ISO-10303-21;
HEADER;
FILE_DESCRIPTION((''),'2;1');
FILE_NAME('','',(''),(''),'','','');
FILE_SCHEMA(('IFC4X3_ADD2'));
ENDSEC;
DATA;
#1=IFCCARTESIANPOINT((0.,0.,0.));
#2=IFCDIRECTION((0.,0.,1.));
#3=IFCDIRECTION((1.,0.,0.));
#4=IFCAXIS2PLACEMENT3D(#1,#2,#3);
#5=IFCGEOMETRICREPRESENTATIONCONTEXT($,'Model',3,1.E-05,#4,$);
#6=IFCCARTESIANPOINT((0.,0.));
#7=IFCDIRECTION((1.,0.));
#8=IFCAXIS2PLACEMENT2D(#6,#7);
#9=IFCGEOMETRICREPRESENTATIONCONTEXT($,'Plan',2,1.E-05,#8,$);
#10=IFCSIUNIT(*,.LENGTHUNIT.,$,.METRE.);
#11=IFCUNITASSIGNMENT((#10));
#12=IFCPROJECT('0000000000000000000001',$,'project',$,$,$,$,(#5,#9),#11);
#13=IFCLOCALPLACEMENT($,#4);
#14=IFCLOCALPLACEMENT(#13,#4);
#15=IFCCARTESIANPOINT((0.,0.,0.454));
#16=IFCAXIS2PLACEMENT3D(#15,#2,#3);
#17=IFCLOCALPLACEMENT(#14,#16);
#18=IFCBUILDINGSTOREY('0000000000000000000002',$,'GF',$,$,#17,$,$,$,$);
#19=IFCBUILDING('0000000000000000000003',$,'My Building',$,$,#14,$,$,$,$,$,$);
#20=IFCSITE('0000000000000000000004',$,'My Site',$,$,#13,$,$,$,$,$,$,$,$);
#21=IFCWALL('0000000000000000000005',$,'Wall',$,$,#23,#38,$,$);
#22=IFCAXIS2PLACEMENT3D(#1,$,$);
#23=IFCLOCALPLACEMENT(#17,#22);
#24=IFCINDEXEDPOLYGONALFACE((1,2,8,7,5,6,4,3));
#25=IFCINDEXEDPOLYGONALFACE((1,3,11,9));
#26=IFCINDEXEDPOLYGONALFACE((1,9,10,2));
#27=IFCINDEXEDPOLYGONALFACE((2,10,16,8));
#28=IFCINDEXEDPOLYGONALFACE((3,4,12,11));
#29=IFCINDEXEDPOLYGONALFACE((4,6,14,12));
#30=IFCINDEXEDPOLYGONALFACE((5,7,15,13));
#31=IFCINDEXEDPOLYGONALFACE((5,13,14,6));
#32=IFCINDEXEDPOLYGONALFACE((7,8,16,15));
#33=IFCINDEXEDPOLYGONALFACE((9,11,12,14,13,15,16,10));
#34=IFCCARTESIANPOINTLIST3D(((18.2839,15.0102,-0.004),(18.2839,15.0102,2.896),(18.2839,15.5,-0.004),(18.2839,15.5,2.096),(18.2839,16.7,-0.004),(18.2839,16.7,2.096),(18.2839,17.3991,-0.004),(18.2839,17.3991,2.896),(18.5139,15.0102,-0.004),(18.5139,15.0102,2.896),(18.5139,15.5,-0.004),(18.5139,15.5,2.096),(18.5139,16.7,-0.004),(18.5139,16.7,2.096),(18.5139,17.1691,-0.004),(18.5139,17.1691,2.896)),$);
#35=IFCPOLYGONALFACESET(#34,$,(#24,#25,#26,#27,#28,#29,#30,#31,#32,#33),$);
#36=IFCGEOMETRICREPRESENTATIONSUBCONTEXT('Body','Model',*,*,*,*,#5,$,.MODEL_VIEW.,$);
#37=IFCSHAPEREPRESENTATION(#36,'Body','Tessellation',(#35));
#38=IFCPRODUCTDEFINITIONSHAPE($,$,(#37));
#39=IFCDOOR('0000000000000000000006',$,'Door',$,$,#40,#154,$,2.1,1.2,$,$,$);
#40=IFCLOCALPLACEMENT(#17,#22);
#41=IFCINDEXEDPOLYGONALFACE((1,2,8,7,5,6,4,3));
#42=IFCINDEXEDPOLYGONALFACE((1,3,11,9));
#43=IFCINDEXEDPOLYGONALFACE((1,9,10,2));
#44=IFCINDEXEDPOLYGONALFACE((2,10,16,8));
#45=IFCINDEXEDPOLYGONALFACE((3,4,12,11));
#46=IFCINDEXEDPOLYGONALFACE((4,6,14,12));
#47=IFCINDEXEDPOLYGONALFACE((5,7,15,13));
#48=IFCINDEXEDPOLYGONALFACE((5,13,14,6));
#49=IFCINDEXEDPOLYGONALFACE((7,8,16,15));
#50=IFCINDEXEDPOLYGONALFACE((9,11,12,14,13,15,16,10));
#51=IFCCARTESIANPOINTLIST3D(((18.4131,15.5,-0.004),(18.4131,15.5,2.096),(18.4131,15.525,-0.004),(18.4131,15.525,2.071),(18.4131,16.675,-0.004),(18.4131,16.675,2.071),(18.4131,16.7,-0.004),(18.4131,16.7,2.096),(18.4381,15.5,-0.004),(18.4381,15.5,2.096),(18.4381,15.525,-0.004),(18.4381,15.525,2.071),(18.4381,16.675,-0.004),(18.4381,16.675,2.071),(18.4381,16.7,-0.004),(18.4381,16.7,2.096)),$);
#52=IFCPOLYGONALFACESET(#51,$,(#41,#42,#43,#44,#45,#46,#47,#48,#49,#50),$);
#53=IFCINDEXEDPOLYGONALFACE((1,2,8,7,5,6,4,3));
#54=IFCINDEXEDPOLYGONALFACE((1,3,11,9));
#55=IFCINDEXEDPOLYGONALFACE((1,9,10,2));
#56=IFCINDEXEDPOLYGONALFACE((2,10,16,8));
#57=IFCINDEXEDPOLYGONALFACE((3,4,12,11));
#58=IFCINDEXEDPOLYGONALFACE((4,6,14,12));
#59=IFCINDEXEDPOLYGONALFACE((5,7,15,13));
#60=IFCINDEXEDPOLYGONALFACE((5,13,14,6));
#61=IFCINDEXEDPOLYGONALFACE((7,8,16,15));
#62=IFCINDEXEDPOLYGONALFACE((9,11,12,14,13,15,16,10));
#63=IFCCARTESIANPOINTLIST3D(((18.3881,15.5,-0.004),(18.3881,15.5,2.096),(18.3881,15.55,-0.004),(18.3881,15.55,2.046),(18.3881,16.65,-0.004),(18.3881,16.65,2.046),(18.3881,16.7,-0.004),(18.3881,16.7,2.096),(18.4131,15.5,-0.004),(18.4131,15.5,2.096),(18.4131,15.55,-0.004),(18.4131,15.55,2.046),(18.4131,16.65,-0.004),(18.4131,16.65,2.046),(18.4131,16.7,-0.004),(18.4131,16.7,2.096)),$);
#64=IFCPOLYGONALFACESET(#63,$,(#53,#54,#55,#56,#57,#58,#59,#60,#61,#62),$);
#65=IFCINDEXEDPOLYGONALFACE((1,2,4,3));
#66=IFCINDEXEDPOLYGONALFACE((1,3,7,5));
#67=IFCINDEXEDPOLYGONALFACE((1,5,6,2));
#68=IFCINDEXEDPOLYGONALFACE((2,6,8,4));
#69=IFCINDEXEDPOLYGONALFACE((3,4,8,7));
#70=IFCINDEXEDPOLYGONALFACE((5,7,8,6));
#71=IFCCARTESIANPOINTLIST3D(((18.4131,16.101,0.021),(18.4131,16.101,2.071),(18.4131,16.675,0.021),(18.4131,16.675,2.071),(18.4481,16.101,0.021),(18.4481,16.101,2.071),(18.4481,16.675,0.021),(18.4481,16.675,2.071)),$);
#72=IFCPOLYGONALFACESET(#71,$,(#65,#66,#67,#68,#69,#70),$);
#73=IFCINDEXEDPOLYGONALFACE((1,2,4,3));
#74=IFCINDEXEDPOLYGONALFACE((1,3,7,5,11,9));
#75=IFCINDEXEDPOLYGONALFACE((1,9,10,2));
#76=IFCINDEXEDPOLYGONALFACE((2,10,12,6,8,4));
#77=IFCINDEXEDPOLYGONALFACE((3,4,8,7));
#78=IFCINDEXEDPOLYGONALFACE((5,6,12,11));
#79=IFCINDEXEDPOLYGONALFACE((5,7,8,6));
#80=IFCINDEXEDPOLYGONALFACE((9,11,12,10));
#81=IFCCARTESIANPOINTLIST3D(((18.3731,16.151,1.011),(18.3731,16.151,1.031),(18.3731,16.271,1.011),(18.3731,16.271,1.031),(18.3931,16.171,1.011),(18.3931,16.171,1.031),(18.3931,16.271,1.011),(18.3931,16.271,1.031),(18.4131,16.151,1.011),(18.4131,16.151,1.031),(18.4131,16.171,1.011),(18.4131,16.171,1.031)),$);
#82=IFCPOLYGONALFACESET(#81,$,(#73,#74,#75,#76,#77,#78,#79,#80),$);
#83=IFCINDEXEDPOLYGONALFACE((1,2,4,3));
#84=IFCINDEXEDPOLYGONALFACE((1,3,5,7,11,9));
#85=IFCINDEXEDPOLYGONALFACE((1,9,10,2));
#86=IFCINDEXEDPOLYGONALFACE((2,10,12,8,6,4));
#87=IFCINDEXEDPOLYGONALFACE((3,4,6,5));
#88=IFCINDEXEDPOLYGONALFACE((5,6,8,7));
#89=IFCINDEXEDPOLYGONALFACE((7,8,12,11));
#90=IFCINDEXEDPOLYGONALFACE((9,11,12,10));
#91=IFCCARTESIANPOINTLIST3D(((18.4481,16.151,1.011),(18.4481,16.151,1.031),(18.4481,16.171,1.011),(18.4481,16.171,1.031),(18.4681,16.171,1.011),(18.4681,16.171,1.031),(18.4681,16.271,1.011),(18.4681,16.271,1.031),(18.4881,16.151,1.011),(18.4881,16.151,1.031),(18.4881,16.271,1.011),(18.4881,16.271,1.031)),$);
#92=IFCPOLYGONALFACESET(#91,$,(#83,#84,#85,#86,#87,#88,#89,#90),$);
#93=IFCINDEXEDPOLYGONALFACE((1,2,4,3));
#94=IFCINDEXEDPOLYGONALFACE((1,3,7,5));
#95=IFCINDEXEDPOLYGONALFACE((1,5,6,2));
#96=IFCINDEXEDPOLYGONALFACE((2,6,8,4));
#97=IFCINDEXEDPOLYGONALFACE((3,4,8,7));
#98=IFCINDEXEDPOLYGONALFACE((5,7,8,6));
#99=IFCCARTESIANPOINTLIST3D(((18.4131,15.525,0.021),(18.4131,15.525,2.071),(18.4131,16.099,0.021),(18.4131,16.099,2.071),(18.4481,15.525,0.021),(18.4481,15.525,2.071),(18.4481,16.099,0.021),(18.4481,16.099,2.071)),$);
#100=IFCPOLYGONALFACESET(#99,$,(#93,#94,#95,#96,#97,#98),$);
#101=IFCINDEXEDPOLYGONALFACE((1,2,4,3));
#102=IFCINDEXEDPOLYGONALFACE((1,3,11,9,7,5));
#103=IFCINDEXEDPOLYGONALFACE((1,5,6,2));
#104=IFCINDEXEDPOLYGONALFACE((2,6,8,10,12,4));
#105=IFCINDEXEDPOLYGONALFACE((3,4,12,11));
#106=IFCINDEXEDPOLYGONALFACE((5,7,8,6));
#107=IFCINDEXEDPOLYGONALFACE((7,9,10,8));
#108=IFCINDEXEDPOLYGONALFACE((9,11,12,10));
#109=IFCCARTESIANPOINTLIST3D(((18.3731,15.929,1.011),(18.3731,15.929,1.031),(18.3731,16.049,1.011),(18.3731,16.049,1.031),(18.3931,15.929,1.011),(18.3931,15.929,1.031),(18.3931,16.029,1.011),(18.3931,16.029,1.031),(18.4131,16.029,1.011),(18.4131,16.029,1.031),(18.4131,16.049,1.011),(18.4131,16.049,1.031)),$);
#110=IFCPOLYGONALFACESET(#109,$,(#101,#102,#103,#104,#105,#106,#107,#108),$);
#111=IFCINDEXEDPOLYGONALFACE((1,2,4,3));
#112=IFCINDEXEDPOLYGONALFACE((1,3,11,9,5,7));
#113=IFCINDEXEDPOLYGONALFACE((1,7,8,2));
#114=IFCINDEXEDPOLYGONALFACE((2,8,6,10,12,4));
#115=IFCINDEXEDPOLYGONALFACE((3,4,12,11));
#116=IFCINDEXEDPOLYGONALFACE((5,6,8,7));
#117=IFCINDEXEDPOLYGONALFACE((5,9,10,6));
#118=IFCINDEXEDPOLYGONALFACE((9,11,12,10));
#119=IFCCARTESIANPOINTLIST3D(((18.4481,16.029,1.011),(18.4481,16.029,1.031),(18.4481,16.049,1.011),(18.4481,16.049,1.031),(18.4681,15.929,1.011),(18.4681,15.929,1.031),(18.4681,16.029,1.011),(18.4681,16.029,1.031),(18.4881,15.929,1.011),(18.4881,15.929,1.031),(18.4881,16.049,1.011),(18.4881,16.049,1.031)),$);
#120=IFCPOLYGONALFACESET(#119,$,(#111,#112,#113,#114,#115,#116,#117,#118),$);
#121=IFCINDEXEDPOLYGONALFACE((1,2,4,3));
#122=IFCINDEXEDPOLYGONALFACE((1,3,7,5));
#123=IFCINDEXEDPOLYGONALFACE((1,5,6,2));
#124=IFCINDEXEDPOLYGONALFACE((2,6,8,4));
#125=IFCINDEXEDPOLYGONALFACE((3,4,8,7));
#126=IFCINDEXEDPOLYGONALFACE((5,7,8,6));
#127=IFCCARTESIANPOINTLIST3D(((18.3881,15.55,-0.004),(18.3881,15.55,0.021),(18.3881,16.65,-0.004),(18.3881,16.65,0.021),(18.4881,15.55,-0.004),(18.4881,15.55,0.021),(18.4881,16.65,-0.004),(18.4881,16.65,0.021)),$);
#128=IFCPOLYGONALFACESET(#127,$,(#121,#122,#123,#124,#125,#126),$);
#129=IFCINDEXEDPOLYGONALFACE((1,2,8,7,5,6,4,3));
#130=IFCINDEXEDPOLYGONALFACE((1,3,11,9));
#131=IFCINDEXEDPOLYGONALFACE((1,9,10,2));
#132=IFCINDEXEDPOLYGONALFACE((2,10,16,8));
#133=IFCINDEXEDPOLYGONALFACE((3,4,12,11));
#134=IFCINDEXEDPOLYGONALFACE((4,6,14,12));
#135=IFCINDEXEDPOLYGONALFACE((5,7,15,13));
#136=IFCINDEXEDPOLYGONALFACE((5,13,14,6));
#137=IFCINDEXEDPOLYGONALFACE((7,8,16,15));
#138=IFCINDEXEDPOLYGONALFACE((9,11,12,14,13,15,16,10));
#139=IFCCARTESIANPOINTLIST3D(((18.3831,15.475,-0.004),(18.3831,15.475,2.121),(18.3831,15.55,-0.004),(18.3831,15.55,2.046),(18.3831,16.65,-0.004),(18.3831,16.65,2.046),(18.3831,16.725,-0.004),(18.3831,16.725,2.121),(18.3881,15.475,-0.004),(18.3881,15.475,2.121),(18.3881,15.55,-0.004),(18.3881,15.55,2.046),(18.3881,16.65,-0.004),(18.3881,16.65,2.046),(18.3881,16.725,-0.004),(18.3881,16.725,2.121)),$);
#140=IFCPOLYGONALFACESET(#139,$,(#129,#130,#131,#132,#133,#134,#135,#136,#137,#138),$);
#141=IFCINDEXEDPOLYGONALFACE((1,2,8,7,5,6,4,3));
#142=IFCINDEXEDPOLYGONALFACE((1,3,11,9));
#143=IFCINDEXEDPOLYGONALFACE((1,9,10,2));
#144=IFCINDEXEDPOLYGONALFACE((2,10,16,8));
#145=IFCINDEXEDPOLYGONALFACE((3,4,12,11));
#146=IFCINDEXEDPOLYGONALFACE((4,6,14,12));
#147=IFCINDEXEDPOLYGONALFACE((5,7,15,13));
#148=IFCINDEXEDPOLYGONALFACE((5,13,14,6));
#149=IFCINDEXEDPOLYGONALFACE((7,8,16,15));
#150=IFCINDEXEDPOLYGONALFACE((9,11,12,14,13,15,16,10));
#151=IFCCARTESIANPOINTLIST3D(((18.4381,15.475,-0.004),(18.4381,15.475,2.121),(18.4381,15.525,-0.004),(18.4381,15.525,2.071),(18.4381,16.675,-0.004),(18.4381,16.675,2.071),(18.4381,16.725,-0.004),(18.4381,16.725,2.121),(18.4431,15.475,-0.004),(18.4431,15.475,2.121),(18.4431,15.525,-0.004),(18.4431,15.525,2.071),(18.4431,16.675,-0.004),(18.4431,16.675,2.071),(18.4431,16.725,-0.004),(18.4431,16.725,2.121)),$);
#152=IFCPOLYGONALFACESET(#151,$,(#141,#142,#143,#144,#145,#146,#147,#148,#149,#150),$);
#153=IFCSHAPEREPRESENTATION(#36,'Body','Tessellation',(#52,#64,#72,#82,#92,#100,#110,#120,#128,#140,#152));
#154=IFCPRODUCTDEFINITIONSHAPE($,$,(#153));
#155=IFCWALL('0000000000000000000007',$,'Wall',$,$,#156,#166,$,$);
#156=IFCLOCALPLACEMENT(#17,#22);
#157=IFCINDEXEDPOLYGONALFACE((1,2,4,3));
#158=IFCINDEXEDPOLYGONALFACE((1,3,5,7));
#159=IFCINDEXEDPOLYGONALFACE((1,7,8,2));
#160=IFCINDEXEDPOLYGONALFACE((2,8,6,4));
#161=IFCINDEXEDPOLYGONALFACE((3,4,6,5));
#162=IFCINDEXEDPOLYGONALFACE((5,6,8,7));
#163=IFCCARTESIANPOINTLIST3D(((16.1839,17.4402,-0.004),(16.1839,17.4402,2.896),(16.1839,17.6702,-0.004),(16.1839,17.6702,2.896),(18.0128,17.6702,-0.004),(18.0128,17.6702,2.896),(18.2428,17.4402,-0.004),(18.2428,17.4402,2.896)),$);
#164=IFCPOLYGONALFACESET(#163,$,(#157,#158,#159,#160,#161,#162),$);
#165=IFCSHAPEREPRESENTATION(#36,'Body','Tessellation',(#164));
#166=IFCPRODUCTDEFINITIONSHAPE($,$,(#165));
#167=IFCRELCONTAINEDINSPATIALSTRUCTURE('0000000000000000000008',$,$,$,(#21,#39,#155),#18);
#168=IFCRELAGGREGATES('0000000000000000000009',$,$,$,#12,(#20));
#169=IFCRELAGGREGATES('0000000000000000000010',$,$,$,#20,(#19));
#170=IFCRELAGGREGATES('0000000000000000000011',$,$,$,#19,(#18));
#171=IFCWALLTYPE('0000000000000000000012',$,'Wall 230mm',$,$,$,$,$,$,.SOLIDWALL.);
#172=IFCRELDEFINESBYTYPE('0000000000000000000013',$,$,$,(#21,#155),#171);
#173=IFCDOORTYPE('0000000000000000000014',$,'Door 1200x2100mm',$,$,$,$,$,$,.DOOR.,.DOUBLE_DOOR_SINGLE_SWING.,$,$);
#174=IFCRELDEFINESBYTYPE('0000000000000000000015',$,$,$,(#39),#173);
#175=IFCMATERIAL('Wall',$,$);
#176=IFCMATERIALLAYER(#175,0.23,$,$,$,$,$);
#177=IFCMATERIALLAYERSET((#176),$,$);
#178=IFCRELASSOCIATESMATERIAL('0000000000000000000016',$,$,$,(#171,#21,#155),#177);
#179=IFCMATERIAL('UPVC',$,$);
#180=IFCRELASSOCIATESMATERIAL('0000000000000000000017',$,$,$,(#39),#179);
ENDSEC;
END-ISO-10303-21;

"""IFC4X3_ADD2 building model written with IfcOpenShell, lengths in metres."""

from ifc_helpers import new_model, entity, si_unit, frame, origin_with_axes, origin_2d_with_axis, place, context, subcontext, project, spatial, line, indexed_curve, outline, extrude, clip, halfspace, shape, source, transform, mapped, material, layer, layer_set, layer_usage, type_object, type_shapes, element, fill, save


model = new_model("IFC4X3_ADD2")

# Units and contexts
model_context = context("Model", 3, precision=1e-05, world=origin_with_axes())
plan_context = context("Plan", 2, precision=1e-05, world=origin_2d_with_axis())
body_context_1 = subcontext(model_context, "Body", "Model", "MODEL_VIEW")
body_context_2 = subcontext(plan_context, "Body", "Plan", "PLAN_VIEW")
ifc_project = project(units=[si_unit("LENGTHUNIT", "METRE")], contexts=[model_context, plan_context])

# Site, building, storey
site_placement = place(None, origin_with_axes())
site = spatial("IfcSite", under=ifc_project, at=site_placement, Name="My Site")
building_placement = place(site_placement, origin_with_axes())
building = spatial("IfcBuilding", under=site, at=building_placement, Name="My Building")
storey_placement = place(building_placement, frame((0.0, 0.0, 0.454), z_axis=(0.0, 0.0, 1.0), x_axis=(1.0, 0.0, 0.0)))
storey = spatial("IfcBuildingStorey", under=building, at=storey_placement, Name="GF")

# Shared definitions
ifc_material_1 = material(Name="Wall")

# Shared definitions
ifc_layer_1 = layer(ifc_material_1, 0.23)
ifc_layer_set_1 = layer_set([ifc_layer_1])
wall_type_1 = type_object("IfcWallType", Name="Wall 230mm", PredefinedType="SOLIDWALL", material=ifc_layer_set_1)

# Wall, opening, door
ifc_material_2 = material(Name="UPVC")
ifc_layer_usage_1 = layer_usage(ifc_layer_set_1, "AXIS2", "POSITIVE", 0.0)
wall_1_placement = place(storey_placement, frame((18.5139, 15.0102, -0.004), z_axis=(0.0, 0.0, 1.0), x_axis=(0.000001, 1.0, 0.0)))
wall_1 = element("IfcWall", 1, at=wall_1_placement, inside=storey, type_object=wall_type_1, material=ifc_layer_usage_1, Name="Wall", context=body_context_1, shape_type="Clipping", body=[
    clip(extrude(outline(indexed_curve([(0.0, 0.0), (0.0, 0.23), (2.3889, 0.23), (2.3889, 0.0), (0.0, 0.0)], self_intersect=False)), origin_with_axes(), (0.0, 0.0, 1.0), 2.9), halfspace(frame((2.1589, 0.0, -0.45), z_axis=(0.666999, -0.666993, 0.0), x_axis=(-0.707103, -0.70711, 0.0)), False)),
])
shared_shape_1 = source(origin_with_axes(), body_context_1, "Body", "SweptSolid", [
    extrude(outline(indexed_curve([(0.0, 0.0), (1.2, 0.0), (1.2, 2.1), (0.0, 2.1)], segments=[line(1, 2, 3, 4, 1)])), frame((0.0, -0.6, 0.0), z_axis=(0.0, -1.0, 0.0), x_axis=(1.0, 0.0, 0.0)), (0.0, 0.0, -1.0), 1.2),
])
opening_1_placement = place(wall_1_placement, frame((0.4898, 0.0, 0.0), z_axis=(0.0, 0.0, 1.0), x_axis=(1.0, 0.0, 0.0)))
opening_1 = element("IfcOpeningElement", 2, at=opening_1_placement, cuts=wall_1, PredefinedType="OPENING", context=body_context_1, shape_type="MappedRepresentation", body=[
    mapped(shared_shape_1, transform((0.0, 0.0, 0.0), x_axis=(1.0, 0.0, 0.0), y_axis=(0.0, 1.0, 0.0), z_axis=(0.0, 0.0, 1.0), scale=1.0)),
])
door_type_1 = type_object("IfcDoorType", Name="Door 1200x2100mm", OperationType="DOUBLE_DOOR_SINGLE_SWING", PredefinedType="DOOR")
shared_shape_2 = source(origin_with_axes(), body_context_1, "Body", "SweptSolid", [
    extrude(outline(indexed_curve([(0.0, 0.0), (0.0, 2.1), (1.2, 2.1), (1.2, 0.0), (1.175, 0.0), (1.175, 2.075), (0.025, 2.075), (0.025, 0.0)], segments=[line(1, 2, 3, 4, 5, 6, 7, 8, 1)])), frame((0.0, 0.025, 0.0), z_axis=(0.0, -1.0, 0.0), x_axis=(1.0, 0.0, 0.0)), (0.0, 0.0, -1.0), 0.025),
    extrude(outline(indexed_curve([(0.0, 0.0), (0.0, 2.1), (1.2, 2.1), (1.2, 0.0), (1.15, 0.0), (1.15, 2.05), (0.05, 2.05), (0.05, 0.0)], segments=[line(1, 2, 3, 4, 5, 6, 7, 8, 1)])), frame((0.0, 0.0, 0.0), z_axis=(0.0, -1.0, 0.0), x_axis=(1.0, 0.0, 0.0)), (0.0, 0.0, -1.0), 0.025),
    extrude(outline(indexed_curve([(0.0, 0.0), (0.574, 0.0), (0.574, 0.035), (0.0, 0.035)], segments=[line(1, 2, 3, 4, 1)])), frame((0.025, 0.025, 0.025), z_axis=(0.0, 0.0, 1.0), x_axis=(1.0, 0.0, 0.0)), (0.0, 0.0, 1.0), 2.05),
    extrude(outline(indexed_curve([(0.0, 0.0), (0.0, -0.04), (-0.12, -0.04), (-0.12, -0.02), (-0.02, -0.02), (-0.02, 0.0)], segments=[line(1, 2, 3, 4, 5, 6, 1)])), frame((0.549, 0.025, 1.015), z_axis=(0.0, 0.0, 1.0), x_axis=(1.0, 0.0, 0.0)), (0.0, 0.0, 1.0), 0.02),
    extrude(outline(indexed_curve([(0.0, 0.0), (0.0, 0.04), (-0.12, 0.04), (-0.12, 0.02), (-0.02, 0.02), (-0.02, 0.0)], segments=[line(1, 2, 3, 4, 5, 6, 1)])), frame((0.549, 0.06, 1.015), z_axis=(0.0, 0.0, 1.0), x_axis=(1.0, 0.0, 0.0)), (0.0, 0.0, 1.0), 0.02),
    extrude(outline(indexed_curve([(0.0, 0.0), (-0.574, 0.0), (-0.574, 0.035), (0.0, 0.035)], segments=[line(1, 2, 3, 4, 1)])), frame((1.175, 0.025, 0.025), z_axis=(0.0, 0.0, 1.0), x_axis=(1.0, 0.0, 0.0)), (0.0, 0.0, 1.0), 2.05),
    extrude(outline(indexed_curve([(0.0, 0.0), (0.0, -0.04), (0.12, -0.04), (0.12, -0.02), (0.02, -0.02), (0.02, 0.0)], segments=[line(1, 2, 3, 4, 5, 6, 1)])), frame((0.651, 0.025, 1.015), z_axis=(0.0, 0.0, 1.0), x_axis=(1.0, 0.0, 0.0)), (0.0, 0.0, 1.0), 0.02),
    extrude(outline(indexed_curve([(0.0, 0.0), (0.0, 0.04), (0.12, 0.04), (0.12, 0.02), (0.02, 0.02), (0.02, 0.0)], segments=[line(1, 2, 3, 4, 5, 6, 1)])), frame((0.651, 0.06, 1.015), z_axis=(0.0, 0.0, 1.0), x_axis=(1.0, 0.0, 0.0)), (0.0, 0.0, 1.0), 0.02),
    extrude(outline(indexed_curve([(0.0, 0.0), (1.1, 0.0), (1.1, 0.1), (0.0, 0.1)], segments=[line(1, 2, 3, 4, 1)])), frame((0.05, 0.0, 0.0), z_axis=(0.0, 0.0, 1.0), x_axis=(1.0, 0.0, 0.0)), (0.0, 0.0, 1.0), 0.025),
    extrude(outline(indexed_curve([(0.0, 0.0), (0.0, 2.125), (1.25, 2.125), (1.25, 0.0), (1.175, 0.0), (1.175, 2.05), (0.075, 2.05), (0.075, 0.0)], segments=[line(1, 2, 3, 4, 5, 6, 7, 8, 1)])), frame((-0.025, -0.005, 0.0), z_axis=(0.0, -1.0, 0.0), x_axis=(1.0, 0.0, 0.0)), (0.0, 0.0, -1.0), 0.005),
    extrude(outline(indexed_curve([(0.0, 0.0), (0.0, 2.125), (1.25, 2.125), (1.25, 0.0), (1.2, 0.0), (1.2, 2.075), (0.05, 2.075), (0.05, 0.0)], segments=[line(1, 2, 3, 4, 5, 6, 7, 8, 1)])), frame((-0.025, 0.05, 0.0), z_axis=(0.0, -1.0, 0.0), x_axis=(1.0, 0.0, 0.0)), (0.0, 0.0, -1.0), 0.005),
])
shared_shape_3 = source(origin_with_axes(), body_context_2, "Body", "Curve2D", [
    entity("IfcIndexedPolyCurve", entity("IfcCartesianPointList2D", [[0.0, 0.0], [0.0, 0.05], [0.025, 0.05], [0.025, 0.025], [0.05, 0.025], [0.05, 0.0]]), [entity("IfcLineIndex", [1, 2, 3, 4, 5, 6, 1])]),
    entity("IfcIndexedPolyCurve", entity("IfcCartesianPointList2D", [[1.2, 0.0], [1.2, 0.05], [1.175, 0.05], [1.175, 0.025], [1.15, 0.025], [1.15, 0.0]]), [entity("IfcLineIndex", [1, 2, 3, 4, 5, 6, 1])]),
    entity("IfcTrimmedCurve", entity("IfcEllipse", entity("IfcAxis2Placement2D", entity("IfcCartesianPoint", [0.06, 0.05]), entity("IfcDirection", [1.0, 0.0])), 0.54, 0.575), [entity("IfcCartesianPoint", [0.6, 0.05])], [entity("IfcCartesianPoint", [0.06, 0.625])], True, "CARTESIAN"),
    entity("IfcIndexedPolyCurve", entity("IfcCartesianPointList2D", [[0.025, 0.05], [0.06, 0.05], [0.06, 0.625], [0.025, 0.625]]), [entity("IfcLineIndex", [1, 2, 3, 4, 1])]),
    entity("IfcTrimmedCurve", entity("IfcEllipse", entity("IfcAxis2Placement2D", entity("IfcCartesianPoint", [1.14, 0.05]), entity("IfcDirection", [1.0, 0.0])), 0.54, 0.575), [entity("IfcCartesianPoint", [1.14, 0.625])], [entity("IfcCartesianPoint", [0.6, 0.05])], True, "CARTESIAN"),
    entity("IfcIndexedPolyCurve", entity("IfcCartesianPointList2D", [[1.175, 0.05], [1.14, 0.05], [1.14, 0.625], [1.175, 0.625]]), [entity("IfcLineIndex", [1, 2, 3, 4, 1])]),
])
type_shapes(door_type_1, [shared_shape_2, shared_shape_3])
door_1_placement = place(opening_1_placement, frame((1.2, 0.1258, 0.0), z_axis=(0.0, 0.0, 1.0), x_axis=(-1.0, 0.0, 0.0)))
door_1 = element("IfcDoor", 3, at=door_1_placement, inside=storey, type_object=door_type_1, material=ifc_material_2, Name="Door", OverallHeight=2.1, OverallWidth=1.2, shapes=[
    shape(body_context_1, "Body", "MappedRepresentation", [mapped(shared_shape_2, transform((0.0, 0.0, 0.0), x_axis=(1.0, 0.0, 0.0), y_axis=(0.0, 1.0, 0.0), z_axis=(0.0, 0.0, 1.0), scale=1.0))]),
    shape(body_context_2, "Body", "MappedRepresentation", [mapped(shared_shape_3, transform((0.0, 0.0, 0.0), x_axis=(1.0, 0.0, 0.0), y_axis=(0.0, 1.0, 0.0), z_axis=(0.0, 0.0, 1.0), scale=1.0))]),
])
fill(opening_1, door_1)

# Wall
ifc_layer_usage_2 = layer_usage(ifc_layer_set_1, "AXIS2", "POSITIVE", 0.0)
wall_2_placement = place(storey_placement, frame((18.2428, 17.6702, -0.004), z_axis=(0.0, 0.0, 1.0), x_axis=(-1.0, 0.0, 0.0)))
element("IfcWall", 4, at=wall_2_placement, inside=storey, type_object=wall_type_1, material=ifc_layer_usage_2, Name="Wall", context=body_context_1, shape_type="Clipping", body=[
    clip(extrude(outline(indexed_curve([(0.0, 0.0), (0.0, 0.23), (2.0589, 0.23), (2.0589, 0.0), (0.0, 0.0)], self_intersect=False)), origin_with_axes(), (0.0, 0.0, 1.0), 2.9), halfspace(frame((0.23, 0.0, -0.45), z_axis=(-0.666999, -0.666999, 0.0), x_axis=(-0.707107, 0.707107, 0.0)), False)),
])

save(model, "model.ifc")
